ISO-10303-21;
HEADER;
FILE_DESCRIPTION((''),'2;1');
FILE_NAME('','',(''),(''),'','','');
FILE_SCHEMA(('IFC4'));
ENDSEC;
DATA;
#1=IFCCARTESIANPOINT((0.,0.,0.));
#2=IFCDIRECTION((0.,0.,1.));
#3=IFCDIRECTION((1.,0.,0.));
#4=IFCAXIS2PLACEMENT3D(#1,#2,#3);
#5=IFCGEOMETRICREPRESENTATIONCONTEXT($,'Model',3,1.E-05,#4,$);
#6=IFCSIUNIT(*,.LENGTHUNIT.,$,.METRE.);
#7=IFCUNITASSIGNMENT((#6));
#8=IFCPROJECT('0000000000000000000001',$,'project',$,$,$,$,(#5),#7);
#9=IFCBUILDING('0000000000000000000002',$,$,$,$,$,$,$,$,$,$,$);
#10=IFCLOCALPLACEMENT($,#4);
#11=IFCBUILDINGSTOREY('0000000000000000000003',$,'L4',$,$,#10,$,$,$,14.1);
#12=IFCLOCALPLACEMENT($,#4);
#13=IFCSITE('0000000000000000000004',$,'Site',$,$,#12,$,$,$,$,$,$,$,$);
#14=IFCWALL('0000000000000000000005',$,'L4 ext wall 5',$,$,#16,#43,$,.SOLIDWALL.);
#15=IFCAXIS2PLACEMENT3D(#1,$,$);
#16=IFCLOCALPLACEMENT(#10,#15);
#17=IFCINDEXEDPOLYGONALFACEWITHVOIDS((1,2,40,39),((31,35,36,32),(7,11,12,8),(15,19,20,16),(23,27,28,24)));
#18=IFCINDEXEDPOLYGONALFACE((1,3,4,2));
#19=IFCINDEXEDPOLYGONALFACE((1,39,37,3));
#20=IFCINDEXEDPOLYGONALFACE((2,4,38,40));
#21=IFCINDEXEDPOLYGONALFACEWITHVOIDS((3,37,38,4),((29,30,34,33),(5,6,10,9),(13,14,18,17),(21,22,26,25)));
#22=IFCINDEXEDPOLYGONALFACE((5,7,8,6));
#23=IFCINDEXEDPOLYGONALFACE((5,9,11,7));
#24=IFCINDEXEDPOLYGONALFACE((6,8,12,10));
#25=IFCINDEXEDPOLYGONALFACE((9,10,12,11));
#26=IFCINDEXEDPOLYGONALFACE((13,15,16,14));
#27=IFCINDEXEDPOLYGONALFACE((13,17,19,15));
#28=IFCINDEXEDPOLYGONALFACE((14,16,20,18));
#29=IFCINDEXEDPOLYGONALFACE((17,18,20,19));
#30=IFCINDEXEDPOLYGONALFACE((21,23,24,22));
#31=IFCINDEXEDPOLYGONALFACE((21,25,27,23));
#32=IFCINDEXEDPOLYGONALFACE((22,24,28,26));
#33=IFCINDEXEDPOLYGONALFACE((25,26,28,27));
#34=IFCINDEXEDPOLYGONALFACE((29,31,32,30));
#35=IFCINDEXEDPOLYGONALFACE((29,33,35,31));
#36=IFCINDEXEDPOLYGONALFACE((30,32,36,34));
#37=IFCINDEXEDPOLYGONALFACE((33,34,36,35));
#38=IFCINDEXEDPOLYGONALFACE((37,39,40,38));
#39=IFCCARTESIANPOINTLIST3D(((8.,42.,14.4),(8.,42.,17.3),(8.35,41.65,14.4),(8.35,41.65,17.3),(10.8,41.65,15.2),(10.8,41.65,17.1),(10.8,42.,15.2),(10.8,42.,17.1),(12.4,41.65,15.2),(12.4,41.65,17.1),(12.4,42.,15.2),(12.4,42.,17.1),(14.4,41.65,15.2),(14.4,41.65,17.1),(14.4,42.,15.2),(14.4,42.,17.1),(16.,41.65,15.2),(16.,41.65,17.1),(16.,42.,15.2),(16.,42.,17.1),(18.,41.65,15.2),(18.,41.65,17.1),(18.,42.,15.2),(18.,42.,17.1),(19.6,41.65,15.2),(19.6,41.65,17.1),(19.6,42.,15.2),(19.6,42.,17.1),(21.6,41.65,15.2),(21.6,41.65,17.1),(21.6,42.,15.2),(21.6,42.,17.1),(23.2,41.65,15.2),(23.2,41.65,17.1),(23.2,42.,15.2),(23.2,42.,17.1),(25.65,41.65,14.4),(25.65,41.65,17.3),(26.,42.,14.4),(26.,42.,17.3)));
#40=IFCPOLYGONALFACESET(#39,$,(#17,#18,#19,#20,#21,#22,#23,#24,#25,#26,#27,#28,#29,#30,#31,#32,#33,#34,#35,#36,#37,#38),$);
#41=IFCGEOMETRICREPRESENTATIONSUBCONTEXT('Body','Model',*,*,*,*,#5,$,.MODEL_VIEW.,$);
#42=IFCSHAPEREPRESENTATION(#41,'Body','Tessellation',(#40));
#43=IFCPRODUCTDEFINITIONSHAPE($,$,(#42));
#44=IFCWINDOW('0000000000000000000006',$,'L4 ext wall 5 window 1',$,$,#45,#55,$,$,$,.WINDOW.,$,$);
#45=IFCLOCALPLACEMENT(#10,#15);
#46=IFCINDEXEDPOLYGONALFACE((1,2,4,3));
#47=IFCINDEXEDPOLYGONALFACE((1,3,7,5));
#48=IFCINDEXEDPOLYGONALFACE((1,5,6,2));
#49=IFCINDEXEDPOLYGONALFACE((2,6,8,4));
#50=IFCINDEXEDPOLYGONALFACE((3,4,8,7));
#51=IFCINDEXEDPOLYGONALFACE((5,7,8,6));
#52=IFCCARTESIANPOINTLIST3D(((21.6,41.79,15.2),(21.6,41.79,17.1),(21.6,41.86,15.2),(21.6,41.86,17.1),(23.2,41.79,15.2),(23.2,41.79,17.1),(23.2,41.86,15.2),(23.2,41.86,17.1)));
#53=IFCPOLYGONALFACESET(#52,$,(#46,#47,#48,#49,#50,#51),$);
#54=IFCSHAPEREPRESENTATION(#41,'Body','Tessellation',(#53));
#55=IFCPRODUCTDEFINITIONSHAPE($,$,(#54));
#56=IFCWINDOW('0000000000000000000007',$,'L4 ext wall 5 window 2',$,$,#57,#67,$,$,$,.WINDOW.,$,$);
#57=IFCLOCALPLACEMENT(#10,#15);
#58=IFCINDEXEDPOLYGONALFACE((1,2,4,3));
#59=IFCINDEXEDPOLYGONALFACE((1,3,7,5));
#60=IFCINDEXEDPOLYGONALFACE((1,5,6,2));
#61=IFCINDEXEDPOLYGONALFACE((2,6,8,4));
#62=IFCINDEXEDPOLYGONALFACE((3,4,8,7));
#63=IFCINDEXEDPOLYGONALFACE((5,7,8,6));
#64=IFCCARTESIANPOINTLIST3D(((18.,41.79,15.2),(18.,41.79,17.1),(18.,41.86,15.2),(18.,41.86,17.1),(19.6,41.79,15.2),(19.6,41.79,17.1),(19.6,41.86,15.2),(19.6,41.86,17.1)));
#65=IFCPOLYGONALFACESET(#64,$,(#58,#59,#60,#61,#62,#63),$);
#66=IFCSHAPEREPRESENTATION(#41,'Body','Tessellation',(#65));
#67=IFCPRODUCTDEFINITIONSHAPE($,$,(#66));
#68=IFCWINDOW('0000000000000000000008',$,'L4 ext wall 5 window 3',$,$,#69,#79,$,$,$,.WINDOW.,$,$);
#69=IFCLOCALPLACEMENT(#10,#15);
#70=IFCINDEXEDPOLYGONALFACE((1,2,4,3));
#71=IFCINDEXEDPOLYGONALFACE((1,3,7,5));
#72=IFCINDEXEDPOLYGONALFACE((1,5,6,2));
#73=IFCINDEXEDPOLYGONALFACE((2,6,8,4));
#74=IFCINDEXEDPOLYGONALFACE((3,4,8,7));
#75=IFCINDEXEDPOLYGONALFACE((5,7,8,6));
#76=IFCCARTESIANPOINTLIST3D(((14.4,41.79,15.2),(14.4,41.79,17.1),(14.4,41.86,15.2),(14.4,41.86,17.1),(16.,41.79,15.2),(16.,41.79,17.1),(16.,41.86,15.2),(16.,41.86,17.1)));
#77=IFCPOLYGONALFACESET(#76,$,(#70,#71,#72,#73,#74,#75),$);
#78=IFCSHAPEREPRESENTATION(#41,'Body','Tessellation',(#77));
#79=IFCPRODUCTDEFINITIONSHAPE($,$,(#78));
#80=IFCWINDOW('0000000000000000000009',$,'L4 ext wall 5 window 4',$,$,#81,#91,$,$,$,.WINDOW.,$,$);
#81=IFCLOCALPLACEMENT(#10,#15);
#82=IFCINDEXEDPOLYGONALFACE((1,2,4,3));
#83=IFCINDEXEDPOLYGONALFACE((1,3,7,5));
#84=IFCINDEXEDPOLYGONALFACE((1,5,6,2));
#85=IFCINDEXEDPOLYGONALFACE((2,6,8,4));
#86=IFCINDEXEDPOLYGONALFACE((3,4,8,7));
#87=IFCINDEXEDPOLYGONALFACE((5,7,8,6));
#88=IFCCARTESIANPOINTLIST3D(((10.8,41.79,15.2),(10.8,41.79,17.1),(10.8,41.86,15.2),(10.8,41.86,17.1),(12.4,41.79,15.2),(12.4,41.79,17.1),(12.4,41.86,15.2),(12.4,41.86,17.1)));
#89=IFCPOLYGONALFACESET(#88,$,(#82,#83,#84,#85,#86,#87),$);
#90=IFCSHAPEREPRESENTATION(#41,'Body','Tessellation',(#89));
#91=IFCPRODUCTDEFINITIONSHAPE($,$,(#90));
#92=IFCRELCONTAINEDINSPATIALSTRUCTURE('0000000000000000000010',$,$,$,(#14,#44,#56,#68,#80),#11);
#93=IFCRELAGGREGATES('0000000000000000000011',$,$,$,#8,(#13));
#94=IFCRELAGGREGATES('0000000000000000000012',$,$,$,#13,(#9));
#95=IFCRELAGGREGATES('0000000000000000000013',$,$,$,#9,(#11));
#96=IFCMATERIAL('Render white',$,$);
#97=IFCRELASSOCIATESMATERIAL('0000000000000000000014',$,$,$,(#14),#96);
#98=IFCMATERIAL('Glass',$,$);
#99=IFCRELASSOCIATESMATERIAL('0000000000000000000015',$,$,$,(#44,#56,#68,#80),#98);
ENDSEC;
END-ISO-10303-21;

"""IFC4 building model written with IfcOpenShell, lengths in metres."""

from ifc_helpers import new_model, si_unit, frame, origin_with_axes, place, context, subcontext, project, spatial, polyline, outline, extrude, material, element, fill, save


model = new_model("IFC4")

# Units and contexts
model_context = context("Model", 3, precision=1e-05, world=origin_with_axes())
body_context = subcontext(model_context, "Body", "Model", "MODEL_VIEW")
ifc_project = project(units=[si_unit("LENGTHUNIT", "METRE")], contexts=[model_context])

# Site, building, storey
site_placement = place(None, origin_with_axes())
site = spatial("IfcSite", under=ifc_project, at=site_placement, Name="Site")
building = spatial("IfcBuilding", under=site)
storey_placement = place(None, origin_with_axes())
storey = spatial("IfcBuildingStorey", under=building, at=storey_placement, Name="L4", Elevation=14.1)

# Wall, openings, windows
ifc_material_1 = material(Name="Render white")
wall_1_placement = place(storey_placement, origin_with_axes())
wall_1 = element("IfcWall", 1, at=wall_1_placement, inside=storey, material=ifc_material_1, Name="L4 ext wall 5", PredefinedType="SOLIDWALL", context=body_context, shape_type="SweptSolid", body=[
    extrude(outline(polyline([(26.0, 42.0), (8.0, 42.0), (8.35, 41.65), (25.65, 41.65), (26.0, 42.0)])), frame((0.0, 0.0, 14.4), z_axis=(0.0, 0.0, 1.0), x_axis=(1.0, 0.0, 0.0)), (0.0, 0.0, 1.0), 2.9),
])
opening_1_placement = place(wall_1_placement, origin_with_axes())
opening_1 = element("IfcOpeningElement", 2, at=opening_1_placement, cuts=wall_1, context=body_context, shape_type="SweptSolid", body=[
    extrude(outline(polyline([(23.2, 42.05), (21.6, 42.05), (21.6, 41.6), (23.2, 41.6), (23.2, 42.05)])), frame((0.0, 0.0, 15.2), z_axis=(0.0, 0.0, 1.0), x_axis=(1.0, 0.0, 0.0)), (0.0, 0.0, 1.0), 1.9),
])
opening_2_placement = place(wall_1_placement, origin_with_axes())
opening_2 = element("IfcOpeningElement", 3, at=opening_2_placement, cuts=wall_1, context=body_context, shape_type="SweptSolid", body=[
    extrude(outline(polyline([(19.6, 42.05), (18.0, 42.05), (18.0, 41.6), (19.6, 41.6), (19.6, 42.05)])), frame((0.0, 0.0, 15.2), z_axis=(0.0, 0.0, 1.0), x_axis=(1.0, 0.0, 0.0)), (0.0, 0.0, 1.0), 1.9),
])
opening_3_placement = place(wall_1_placement, origin_with_axes())
opening_3 = element("IfcOpeningElement", 4, at=opening_3_placement, cuts=wall_1, context=body_context, shape_type="SweptSolid", body=[
    extrude(outline(polyline([(16.0, 42.05), (14.4, 42.05), (14.4, 41.6), (16.0, 41.6), (16.0, 42.05)])), frame((0.0, 0.0, 15.2), z_axis=(0.0, 0.0, 1.0), x_axis=(1.0, 0.0, 0.0)), (0.0, 0.0, 1.0), 1.9),
])
opening_4_placement = place(wall_1_placement, origin_with_axes())
opening_4 = element("IfcOpeningElement", 5, at=opening_4_placement, cuts=wall_1, context=body_context, shape_type="SweptSolid", body=[
    extrude(outline(polyline([(12.4, 42.05), (10.8, 42.05), (10.8, 41.6), (12.4, 41.6), (12.4, 42.05)])), frame((0.0, 0.0, 15.2), z_axis=(0.0, 0.0, 1.0), x_axis=(1.0, 0.0, 0.0)), (0.0, 0.0, 1.0), 1.9),
])
ifc_material_2 = material(Name="Glass")
window_1_placement = place(storey_placement, origin_with_axes())
window_1 = element("IfcWindow", 6, at=window_1_placement, inside=storey, material=ifc_material_2, Name="L4 ext wall 5 window 1", PredefinedType="WINDOW", context=body_context, shape_type="SweptSolid", body=[
    extrude(outline(polyline([(23.2, 41.86), (21.6, 41.86), (21.6, 41.79), (23.2, 41.79), (23.2, 41.86)])), frame((0.0, 0.0, 15.2), z_axis=(0.0, 0.0, 1.0), x_axis=(1.0, 0.0, 0.0)), (0.0, 0.0, 1.0), 1.9),
])
fill(opening_1, window_1)
window_2_placement = place(storey_placement, origin_with_axes())
window_2 = element("IfcWindow", 7, at=window_2_placement, inside=storey, material=ifc_material_2, Name="L4 ext wall 5 window 2", PredefinedType="WINDOW", context=body_context, shape_type="SweptSolid", body=[
    extrude(outline(polyline([(19.6, 41.86), (18.0, 41.86), (18.0, 41.79), (19.6, 41.79), (19.6, 41.86)])), frame((0.0, 0.0, 15.2), z_axis=(0.0, 0.0, 1.0), x_axis=(1.0, 0.0, 0.0)), (0.0, 0.0, 1.0), 1.9),
])
fill(opening_2, window_2)
window_3_placement = place(storey_placement, origin_with_axes())
window_3 = element("IfcWindow", 8, at=window_3_placement, inside=storey, material=ifc_material_2, Name="L4 ext wall 5 window 3", PredefinedType="WINDOW", context=body_context, shape_type="SweptSolid", body=[
    extrude(outline(polyline([(16.0, 41.86), (14.4, 41.86), (14.4, 41.79), (16.0, 41.79), (16.0, 41.86)])), frame((0.0, 0.0, 15.2), z_axis=(0.0, 0.0, 1.0), x_axis=(1.0, 0.0, 0.0)), (0.0, 0.0, 1.0), 1.9),
])
fill(opening_3, window_3)
window_4_placement = place(storey_placement, origin_with_axes())
window_4 = element("IfcWindow", 9, at=window_4_placement, inside=storey, material=ifc_material_2, Name="L4 ext wall 5 window 4", PredefinedType="WINDOW", context=body_context, shape_type="SweptSolid", body=[
    extrude(outline(polyline([(12.4, 41.86), (10.8, 41.86), (10.8, 41.79), (12.4, 41.79), (12.4, 41.86)])), frame((0.0, 0.0, 15.2), z_axis=(0.0, 0.0, 1.0), x_axis=(1.0, 0.0, 0.0)), (0.0, 0.0, 1.0), 1.9),
])
fill(opening_4, window_4)

save(model, "model.ifc")
